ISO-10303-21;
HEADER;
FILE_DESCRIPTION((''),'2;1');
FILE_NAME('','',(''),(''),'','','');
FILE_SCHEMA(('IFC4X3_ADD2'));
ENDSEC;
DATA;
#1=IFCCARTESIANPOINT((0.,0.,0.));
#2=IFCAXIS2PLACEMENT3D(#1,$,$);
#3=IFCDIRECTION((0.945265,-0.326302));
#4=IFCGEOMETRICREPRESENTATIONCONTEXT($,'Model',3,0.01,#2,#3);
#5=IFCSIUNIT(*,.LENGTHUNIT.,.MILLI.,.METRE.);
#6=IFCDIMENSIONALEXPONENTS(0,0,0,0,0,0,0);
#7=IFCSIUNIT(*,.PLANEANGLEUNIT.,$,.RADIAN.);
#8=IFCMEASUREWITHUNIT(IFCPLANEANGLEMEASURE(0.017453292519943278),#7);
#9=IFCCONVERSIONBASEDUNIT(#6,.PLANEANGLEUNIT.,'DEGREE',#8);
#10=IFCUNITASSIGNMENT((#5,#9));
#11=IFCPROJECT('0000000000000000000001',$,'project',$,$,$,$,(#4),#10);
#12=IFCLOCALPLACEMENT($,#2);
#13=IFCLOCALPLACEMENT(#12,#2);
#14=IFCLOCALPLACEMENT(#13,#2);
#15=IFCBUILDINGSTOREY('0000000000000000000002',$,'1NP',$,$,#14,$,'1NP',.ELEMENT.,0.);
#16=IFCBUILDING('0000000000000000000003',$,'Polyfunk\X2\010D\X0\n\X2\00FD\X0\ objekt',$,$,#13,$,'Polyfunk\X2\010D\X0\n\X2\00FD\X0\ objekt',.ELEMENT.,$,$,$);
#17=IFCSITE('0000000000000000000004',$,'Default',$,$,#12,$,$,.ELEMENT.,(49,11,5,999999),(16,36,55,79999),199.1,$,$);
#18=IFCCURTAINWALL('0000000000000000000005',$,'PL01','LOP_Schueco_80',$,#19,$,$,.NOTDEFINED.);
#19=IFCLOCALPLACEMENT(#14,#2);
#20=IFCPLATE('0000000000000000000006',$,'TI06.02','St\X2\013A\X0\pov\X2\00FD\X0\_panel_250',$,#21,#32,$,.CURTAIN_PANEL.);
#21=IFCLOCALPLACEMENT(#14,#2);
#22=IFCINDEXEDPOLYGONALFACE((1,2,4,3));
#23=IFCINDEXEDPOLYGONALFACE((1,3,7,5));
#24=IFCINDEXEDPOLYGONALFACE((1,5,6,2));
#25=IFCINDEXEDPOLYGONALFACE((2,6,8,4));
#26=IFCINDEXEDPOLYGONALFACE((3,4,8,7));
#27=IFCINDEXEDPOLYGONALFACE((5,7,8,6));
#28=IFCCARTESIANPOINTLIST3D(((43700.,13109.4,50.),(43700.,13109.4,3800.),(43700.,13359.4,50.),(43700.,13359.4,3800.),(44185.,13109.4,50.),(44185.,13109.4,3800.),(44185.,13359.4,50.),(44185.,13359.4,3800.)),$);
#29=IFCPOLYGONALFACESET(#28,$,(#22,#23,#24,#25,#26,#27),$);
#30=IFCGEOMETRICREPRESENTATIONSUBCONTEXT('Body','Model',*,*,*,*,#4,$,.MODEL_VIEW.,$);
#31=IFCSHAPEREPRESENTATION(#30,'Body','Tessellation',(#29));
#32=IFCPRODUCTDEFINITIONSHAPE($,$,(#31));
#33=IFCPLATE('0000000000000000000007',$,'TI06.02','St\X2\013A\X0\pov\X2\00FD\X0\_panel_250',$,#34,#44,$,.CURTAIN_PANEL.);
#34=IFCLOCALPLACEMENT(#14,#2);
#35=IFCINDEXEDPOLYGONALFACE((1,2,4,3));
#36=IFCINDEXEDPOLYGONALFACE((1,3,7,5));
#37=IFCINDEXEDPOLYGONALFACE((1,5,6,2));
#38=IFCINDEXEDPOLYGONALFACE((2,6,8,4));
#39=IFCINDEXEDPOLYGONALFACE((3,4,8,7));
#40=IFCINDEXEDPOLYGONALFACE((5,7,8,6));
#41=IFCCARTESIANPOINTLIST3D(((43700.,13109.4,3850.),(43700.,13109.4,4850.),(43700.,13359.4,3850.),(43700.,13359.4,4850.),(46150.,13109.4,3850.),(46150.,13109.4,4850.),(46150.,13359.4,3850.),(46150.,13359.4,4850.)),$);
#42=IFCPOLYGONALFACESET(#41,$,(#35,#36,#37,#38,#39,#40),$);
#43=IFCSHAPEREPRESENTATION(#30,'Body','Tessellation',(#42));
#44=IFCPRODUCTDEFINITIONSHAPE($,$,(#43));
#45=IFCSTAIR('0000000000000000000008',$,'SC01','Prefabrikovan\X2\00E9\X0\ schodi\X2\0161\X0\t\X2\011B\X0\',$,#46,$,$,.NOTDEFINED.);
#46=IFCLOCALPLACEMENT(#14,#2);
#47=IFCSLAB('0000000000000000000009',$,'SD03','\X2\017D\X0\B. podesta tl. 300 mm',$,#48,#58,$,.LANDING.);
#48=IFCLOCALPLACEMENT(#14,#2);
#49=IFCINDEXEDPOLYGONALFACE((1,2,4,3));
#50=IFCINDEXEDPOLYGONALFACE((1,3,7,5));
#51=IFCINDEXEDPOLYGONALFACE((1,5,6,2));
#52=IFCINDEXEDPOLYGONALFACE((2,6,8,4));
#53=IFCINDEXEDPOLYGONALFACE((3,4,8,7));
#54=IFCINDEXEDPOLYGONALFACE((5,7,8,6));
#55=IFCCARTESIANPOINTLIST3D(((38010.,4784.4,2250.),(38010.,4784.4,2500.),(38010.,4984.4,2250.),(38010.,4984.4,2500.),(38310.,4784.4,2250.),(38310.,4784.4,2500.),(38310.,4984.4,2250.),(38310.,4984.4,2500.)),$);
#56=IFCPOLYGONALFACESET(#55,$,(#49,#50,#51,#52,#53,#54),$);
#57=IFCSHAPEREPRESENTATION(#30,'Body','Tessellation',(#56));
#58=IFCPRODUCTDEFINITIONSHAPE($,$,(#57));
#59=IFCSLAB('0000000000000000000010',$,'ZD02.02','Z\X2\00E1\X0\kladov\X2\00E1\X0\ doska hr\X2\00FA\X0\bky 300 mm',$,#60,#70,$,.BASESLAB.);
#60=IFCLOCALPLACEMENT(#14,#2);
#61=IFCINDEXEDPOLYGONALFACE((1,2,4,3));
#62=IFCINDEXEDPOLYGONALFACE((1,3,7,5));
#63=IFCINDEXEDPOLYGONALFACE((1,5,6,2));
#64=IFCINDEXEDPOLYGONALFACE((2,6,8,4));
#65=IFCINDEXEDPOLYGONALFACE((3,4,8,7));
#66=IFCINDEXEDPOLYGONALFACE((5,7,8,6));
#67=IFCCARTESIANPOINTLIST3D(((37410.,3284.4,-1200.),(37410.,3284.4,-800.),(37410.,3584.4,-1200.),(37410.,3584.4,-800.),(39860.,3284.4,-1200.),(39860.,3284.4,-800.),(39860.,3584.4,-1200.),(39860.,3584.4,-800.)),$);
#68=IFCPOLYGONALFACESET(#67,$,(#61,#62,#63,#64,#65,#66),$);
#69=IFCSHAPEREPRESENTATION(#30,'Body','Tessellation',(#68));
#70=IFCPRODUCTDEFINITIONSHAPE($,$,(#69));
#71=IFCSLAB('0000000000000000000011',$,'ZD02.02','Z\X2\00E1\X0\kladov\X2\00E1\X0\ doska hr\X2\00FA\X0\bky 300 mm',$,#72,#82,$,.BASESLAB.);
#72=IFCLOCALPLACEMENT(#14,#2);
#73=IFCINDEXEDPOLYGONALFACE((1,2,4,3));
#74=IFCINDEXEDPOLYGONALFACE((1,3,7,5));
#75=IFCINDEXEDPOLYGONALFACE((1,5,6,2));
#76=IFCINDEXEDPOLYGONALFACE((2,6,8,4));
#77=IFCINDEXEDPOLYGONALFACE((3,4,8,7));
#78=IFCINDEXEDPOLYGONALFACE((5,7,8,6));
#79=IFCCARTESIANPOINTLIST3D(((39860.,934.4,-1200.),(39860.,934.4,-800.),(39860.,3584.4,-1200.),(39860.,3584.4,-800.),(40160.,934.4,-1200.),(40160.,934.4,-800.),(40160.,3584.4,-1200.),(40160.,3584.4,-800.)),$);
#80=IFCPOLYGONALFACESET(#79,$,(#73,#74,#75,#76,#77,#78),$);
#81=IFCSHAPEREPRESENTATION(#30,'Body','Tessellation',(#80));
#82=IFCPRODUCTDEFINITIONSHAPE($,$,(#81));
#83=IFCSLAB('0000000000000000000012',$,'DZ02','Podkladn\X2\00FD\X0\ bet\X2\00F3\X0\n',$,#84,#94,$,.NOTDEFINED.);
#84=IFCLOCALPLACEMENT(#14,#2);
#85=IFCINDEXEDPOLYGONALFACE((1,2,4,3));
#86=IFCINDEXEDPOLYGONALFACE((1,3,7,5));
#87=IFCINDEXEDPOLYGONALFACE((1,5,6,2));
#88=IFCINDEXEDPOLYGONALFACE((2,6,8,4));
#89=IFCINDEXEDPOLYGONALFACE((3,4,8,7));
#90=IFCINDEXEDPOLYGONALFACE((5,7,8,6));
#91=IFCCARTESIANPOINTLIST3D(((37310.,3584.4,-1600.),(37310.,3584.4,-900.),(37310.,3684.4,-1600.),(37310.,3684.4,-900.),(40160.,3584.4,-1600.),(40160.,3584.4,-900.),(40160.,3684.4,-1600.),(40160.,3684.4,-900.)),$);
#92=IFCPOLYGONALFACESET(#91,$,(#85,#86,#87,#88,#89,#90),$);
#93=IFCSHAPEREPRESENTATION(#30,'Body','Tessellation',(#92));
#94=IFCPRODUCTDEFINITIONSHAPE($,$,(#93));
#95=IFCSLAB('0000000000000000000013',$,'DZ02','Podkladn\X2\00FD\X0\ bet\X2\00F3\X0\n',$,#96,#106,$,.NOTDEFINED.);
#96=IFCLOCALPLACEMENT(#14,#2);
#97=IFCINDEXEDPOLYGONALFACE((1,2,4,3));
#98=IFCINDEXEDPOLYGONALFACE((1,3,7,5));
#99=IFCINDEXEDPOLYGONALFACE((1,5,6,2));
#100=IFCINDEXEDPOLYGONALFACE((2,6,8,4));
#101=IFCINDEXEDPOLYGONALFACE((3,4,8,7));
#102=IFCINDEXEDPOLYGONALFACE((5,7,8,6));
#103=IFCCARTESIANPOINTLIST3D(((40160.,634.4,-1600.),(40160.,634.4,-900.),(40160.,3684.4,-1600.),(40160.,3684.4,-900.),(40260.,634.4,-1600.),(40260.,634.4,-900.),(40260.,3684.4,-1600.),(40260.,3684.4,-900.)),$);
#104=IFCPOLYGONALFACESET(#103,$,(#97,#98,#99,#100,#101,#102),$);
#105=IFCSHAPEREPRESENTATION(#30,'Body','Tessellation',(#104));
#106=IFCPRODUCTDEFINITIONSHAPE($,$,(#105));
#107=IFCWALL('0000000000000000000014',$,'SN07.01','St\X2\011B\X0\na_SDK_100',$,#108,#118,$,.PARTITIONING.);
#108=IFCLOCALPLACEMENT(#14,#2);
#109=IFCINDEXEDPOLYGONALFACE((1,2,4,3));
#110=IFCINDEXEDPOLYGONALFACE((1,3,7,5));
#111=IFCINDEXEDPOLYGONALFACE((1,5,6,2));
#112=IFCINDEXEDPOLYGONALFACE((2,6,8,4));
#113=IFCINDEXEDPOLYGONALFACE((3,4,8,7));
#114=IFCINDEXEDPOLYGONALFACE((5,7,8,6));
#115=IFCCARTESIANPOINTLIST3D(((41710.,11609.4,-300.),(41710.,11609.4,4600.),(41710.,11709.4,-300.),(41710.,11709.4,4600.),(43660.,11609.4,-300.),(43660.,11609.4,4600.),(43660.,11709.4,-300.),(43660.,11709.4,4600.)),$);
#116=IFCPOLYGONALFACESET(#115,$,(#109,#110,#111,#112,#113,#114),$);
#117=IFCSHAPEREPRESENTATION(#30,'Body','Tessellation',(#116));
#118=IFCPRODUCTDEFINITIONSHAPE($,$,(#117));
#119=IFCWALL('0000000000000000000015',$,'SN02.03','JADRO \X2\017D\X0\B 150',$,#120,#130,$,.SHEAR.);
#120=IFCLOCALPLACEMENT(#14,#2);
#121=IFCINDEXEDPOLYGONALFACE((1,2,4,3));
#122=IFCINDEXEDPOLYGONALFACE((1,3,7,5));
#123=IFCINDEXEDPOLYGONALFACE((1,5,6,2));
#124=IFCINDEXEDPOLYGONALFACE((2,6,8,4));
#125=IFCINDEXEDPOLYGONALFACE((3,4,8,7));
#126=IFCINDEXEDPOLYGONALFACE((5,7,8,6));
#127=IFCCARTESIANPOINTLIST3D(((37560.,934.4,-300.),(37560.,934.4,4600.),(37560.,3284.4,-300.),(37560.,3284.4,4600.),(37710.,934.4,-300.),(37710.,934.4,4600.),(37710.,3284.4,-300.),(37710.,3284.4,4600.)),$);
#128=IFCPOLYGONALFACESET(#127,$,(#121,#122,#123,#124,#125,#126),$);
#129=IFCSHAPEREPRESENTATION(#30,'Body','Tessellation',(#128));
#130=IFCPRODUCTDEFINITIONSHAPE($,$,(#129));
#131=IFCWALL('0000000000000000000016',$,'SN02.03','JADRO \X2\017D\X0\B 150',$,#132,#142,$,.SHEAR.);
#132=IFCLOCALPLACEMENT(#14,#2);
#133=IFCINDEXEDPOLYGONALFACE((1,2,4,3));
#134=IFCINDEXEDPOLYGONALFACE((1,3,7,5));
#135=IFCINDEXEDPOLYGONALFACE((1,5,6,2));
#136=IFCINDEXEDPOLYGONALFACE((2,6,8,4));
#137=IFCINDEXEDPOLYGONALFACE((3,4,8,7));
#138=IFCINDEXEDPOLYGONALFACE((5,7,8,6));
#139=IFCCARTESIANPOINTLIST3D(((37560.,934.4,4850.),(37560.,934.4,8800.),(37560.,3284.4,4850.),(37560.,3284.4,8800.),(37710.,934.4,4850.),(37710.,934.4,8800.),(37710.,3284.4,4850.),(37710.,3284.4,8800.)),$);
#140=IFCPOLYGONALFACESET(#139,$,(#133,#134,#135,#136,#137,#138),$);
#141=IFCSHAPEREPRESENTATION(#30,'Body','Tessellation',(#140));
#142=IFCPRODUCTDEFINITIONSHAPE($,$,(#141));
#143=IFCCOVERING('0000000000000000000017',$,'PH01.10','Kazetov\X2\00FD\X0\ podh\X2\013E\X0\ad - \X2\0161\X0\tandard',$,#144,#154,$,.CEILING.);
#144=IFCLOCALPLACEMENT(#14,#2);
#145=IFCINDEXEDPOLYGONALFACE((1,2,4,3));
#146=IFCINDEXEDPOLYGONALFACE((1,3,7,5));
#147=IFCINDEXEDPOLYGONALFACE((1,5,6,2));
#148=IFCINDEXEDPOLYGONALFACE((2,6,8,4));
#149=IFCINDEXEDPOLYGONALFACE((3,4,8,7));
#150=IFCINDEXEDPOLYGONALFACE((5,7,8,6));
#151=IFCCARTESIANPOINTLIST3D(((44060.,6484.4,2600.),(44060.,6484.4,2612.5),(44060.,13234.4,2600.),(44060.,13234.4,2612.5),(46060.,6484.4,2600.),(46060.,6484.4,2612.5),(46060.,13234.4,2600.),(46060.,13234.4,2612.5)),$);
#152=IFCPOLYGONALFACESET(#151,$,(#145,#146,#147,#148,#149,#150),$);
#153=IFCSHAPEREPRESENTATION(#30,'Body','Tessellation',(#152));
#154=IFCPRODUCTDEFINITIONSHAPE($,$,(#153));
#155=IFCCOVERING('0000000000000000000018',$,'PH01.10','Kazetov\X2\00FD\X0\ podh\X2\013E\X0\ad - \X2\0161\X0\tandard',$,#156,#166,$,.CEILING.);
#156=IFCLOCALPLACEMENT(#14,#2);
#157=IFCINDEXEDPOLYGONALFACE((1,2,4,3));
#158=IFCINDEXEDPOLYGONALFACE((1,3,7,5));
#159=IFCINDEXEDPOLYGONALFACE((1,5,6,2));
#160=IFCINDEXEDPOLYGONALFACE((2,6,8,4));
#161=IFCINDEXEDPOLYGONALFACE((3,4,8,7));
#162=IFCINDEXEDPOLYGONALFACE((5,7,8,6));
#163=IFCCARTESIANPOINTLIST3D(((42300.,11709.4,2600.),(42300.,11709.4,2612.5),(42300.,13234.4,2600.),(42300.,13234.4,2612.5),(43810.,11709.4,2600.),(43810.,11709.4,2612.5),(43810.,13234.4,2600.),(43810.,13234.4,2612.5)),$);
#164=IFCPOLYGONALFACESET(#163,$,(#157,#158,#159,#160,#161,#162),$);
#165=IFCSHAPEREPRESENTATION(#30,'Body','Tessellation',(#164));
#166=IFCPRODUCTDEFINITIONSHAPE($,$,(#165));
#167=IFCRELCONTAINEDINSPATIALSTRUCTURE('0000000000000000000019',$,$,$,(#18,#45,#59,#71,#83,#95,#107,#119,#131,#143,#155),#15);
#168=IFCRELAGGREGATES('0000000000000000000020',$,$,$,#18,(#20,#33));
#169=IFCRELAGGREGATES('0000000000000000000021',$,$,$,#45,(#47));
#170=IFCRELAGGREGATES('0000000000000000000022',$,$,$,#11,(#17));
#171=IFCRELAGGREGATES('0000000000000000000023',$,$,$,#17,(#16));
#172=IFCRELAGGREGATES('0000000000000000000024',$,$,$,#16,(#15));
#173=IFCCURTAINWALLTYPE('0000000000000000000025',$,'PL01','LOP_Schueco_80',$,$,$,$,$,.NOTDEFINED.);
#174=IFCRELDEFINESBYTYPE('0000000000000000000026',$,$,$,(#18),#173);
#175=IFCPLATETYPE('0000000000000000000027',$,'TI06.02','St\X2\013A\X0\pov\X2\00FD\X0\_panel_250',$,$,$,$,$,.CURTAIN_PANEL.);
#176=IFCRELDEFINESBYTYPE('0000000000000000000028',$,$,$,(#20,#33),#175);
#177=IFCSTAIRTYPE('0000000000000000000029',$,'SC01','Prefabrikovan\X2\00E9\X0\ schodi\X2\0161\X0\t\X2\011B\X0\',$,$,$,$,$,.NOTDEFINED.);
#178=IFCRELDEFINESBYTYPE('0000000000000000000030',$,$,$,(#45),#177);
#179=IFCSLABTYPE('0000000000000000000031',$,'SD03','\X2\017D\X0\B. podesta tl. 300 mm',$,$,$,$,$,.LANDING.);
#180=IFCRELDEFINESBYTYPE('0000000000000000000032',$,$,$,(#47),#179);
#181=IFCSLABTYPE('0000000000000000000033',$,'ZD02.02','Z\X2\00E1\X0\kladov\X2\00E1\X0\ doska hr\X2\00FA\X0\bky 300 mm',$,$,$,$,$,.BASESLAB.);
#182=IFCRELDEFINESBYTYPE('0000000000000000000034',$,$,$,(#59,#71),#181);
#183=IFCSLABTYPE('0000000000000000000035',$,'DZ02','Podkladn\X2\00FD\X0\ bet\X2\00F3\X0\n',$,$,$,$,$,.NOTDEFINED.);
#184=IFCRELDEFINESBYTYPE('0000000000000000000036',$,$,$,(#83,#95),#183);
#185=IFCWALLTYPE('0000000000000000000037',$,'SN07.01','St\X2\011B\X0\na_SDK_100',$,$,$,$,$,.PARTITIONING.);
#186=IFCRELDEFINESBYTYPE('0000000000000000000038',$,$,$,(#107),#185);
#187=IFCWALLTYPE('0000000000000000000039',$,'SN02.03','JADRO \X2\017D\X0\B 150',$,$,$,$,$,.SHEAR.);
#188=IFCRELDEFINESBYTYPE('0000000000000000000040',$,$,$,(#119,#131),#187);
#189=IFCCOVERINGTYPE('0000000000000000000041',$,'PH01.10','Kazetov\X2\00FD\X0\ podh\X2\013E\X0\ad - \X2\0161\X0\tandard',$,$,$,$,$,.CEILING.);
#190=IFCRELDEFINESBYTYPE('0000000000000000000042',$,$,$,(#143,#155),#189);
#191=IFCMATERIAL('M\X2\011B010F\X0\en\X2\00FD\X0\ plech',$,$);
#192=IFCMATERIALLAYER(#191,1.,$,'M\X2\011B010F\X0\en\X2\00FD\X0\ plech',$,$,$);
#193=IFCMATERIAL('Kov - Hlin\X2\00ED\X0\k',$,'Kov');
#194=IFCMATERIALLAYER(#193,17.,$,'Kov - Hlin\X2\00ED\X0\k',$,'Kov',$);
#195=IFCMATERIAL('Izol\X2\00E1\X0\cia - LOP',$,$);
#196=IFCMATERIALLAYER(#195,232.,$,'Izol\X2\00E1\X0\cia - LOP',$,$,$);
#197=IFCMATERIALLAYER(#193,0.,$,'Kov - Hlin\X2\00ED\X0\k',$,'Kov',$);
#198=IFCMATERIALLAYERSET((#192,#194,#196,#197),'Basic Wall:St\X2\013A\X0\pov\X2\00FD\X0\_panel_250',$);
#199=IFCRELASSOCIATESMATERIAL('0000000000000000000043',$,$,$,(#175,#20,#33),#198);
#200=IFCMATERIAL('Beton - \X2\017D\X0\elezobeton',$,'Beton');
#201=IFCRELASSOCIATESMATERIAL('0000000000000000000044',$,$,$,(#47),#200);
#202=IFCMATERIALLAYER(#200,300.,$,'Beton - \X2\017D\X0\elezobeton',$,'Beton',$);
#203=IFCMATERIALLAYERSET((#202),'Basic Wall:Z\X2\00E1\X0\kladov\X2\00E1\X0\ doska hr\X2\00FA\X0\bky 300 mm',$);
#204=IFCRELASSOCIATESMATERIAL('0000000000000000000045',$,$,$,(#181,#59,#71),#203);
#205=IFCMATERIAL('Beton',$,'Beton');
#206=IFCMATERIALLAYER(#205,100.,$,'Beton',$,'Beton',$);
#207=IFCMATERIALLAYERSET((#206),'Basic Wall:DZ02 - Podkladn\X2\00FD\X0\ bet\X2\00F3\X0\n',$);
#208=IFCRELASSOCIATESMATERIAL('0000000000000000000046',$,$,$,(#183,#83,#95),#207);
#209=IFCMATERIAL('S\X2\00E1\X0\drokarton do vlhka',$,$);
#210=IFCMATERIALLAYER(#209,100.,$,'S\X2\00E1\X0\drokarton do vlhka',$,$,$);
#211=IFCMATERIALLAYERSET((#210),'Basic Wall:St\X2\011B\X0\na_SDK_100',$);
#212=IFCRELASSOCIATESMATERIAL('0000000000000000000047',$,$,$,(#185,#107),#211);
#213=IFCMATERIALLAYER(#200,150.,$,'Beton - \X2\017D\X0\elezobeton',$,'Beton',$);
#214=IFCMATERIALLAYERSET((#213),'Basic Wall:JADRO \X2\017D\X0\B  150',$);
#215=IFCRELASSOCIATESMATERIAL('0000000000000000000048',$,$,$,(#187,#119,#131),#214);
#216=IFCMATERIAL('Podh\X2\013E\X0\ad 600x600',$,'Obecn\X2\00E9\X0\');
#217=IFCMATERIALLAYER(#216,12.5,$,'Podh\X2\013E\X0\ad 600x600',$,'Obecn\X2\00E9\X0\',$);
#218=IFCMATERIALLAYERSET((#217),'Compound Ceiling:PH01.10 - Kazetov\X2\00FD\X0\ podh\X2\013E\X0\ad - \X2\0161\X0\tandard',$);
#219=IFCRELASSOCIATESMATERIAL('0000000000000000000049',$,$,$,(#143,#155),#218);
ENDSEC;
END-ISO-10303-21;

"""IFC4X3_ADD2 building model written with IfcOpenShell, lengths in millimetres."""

from ifc_helpers import new_model, entity, si_unit, converted_unit, direction, frame, frame_2d, origin, place, context, subcontext, project, spatial, polyline, rectangle, extrude, clip, bounded_halfspace, material, layer, layer_set, layer_usage, type_object, element, aggregate, save


model = new_model("IFC4X3_ADD2")

# Units and contexts
model_context = context("Model", 3, precision=0.01, world=origin(), true_north=direction((0.945265, -0.326302)))
body_context = subcontext(model_context, "Body", "Model", "MODEL_VIEW")
ifc_project = project(units=[si_unit("LENGTHUNIT", "METRE", prefix="MILLI"), converted_unit("PLANEANGLEUNIT", "DEGREE", entity("IfcPlaneAngleMeasure", 0.017453292519943278), si_unit("PLANEANGLEUNIT", "RADIAN"), dimensions=[0, 0, 0, 0, 0, 0, 0])], contexts=[model_context])

# Site, building, storey
site_placement = place(None, origin())
site = spatial("IfcSite", under=ifc_project, at=site_placement, Name="Default", CompositionType="ELEMENT", RefLatitude=(49, 11, 5, 999999), RefLongitude=(16, 36, 55, 79999), RefElevation=199.1)
building_placement = place(site_placement, origin())
building = spatial("IfcBuilding", under=site, at=building_placement, Name="Polyfunkčný objekt", LongName="Polyfunkčný objekt", CompositionType="ELEMENT")
storey_placement = place(building_placement, origin())
storey = spatial("IfcBuildingStorey", under=building, at=storey_placement, Name="1NP", LongName="1NP", CompositionType="ELEMENT", Elevation=0.0)

# Curtain wall, plates
curtain_wall_type = type_object("IfcCurtainWallType", Name="PL01", Description="LOP_Schueco_80", PredefinedType="NOTDEFINED")
curtain_wall_placement = place(storey_placement, origin())
curtain_wall = element("IfcCurtainWall", 1, at=curtain_wall_placement, inside=storey, type_object=curtain_wall_type, Name="PL01", Description="LOP_Schueco_80", PredefinedType="NOTDEFINED")
ifc_material_1 = material(Name="Měďený plech")
ifc_layer_1 = layer(ifc_material_1, 1.0, Name="Měďený plech")
ifc_material_2 = material(Name="Kov - Hliník", Category="Kov")
ifc_layer_2 = layer(ifc_material_2, 17.0, Name="Kov - Hliník", Category="Kov")
ifc_material_3 = material(Name="Izolácia - LOP")
ifc_layer_3 = layer(ifc_material_3, 232.0, Name="Izolácia - LOP")
ifc_layer_4 = layer(ifc_material_2, 0.0, Name="Kov - Hliník", Category="Kov")
ifc_layer_set_1 = layer_set([ifc_layer_1, ifc_layer_2, ifc_layer_3, ifc_layer_4], Name="Basic Wall:Stĺpový_panel_250")
ifc_layer_usage_1 = layer_usage(ifc_layer_set_1, "AXIS2", "NEGATIVE", 125.0)
plate_type = type_object("IfcPlateType", Name="TI06.02", Description="Stĺpový_panel_250", PredefinedType="CURTAIN_PANEL", material=ifc_layer_set_1)
plate_1_placement = place(storey_placement, frame((43700.0, 13234.4, 50.0)))
plate_1 = element("IfcPlate", 2, at=plate_1_placement, type_object=plate_type, material=ifc_layer_usage_1, Name="TI06.02", Description="Stĺpový_panel_250", PredefinedType="CURTAIN_PANEL", context=body_context, shape_type="SweptSolid", body=[
    extrude(rectangle(XDim=250.0, YDim=485.0, at=frame_2d((0.0, 0.0), x_axis=(1.0, 0.0))), frame((242.5, 0.0, 0.0), z_axis=(0.0, 0.0, 1.0), x_axis=(0.0, 1.0, 0.0)), (0.0, 0.0, 1.0), 3750.0),
])
ifc_layer_usage_2 = layer_usage(ifc_layer_set_1, "AXIS2", "NEGATIVE", 125.0)
plate_2_placement = place(storey_placement, frame((43700.0, 13234.4, 3850.0)))
plate_2 = element("IfcPlate", 3, at=plate_2_placement, type_object=plate_type, material=ifc_layer_usage_2, Name="TI06.02", Description="Stĺpový_panel_250", PredefinedType="CURTAIN_PANEL", context=body_context, shape_type="SweptSolid", body=[
    extrude(rectangle(XDim=250.0, YDim=2450.0, at=frame_2d((0.0, 0.0), x_axis=(1.0, 0.0))), frame((1225.0, 0.0, 0.0), z_axis=(0.0, 0.0, 1.0), x_axis=(0.0, 1.0, 0.0)), (0.0, 0.0, 1.0), 1000.0),
])
aggregate(curtain_wall, [plate_1, plate_2])

# Stair, slab
stair_type = type_object("IfcStairType", Name="SC01", Description="Prefabrikované schodiště", PredefinedType="NOTDEFINED")
stair_placement = place(storey_placement, origin())
stair = element("IfcStair", 4, at=stair_placement, inside=storey, type_object=stair_type, Name="SC01", Description="Prefabrikované schodiště", PredefinedType="NOTDEFINED")
ifc_material_4 = material(Name="Beton - Železobeton", Category="Beton")
slab_type_1 = type_object("IfcSlabType", Name="SD03", Description="ŽB. podesta tl. 300 mm", PredefinedType="LANDING")
slab_1_placement = place(stair_placement, frame((38010.0, 4784.4, 0.0)))
slab_1 = element("IfcSlab", 5, at=slab_1_placement, type_object=slab_type_1, material=ifc_material_4, Name="SD03", Description="ŽB. podesta tl. 300 mm", PredefinedType="LANDING", context=body_context, shape_type="SweptSolid", body=[
    extrude(rectangle(XDim=200.0, YDim=300.0, at=frame_2d((0.0, 0.0), x_axis=(1.0, 0.0))), frame((150.0, 100.0, 2250.0), z_axis=(0.0, 0.0, 1.0), x_axis=(0.0, 1.0, 0.0)), (0.0, 0.0, 1.0), 250.0),
])
aggregate(stair, [slab_1])

# Slabs
ifc_layer_5 = layer(ifc_material_4, 300.0, Name="Beton - Železobeton", Category="Beton")
ifc_layer_set_2 = layer_set([ifc_layer_5], Name="Basic Wall:Základová doska hrúbky 300 mm")
slab_type_2 = type_object("IfcSlabType", Name="ZD02.02", Description="Základová doska hrúbky 300 mm", PredefinedType="BASESLAB", material=ifc_layer_set_2)
slab_2_placement = place(storey_placement, frame((37410.0, 3434.4, -1200.0)))
element("IfcSlab", 6, at=slab_2_placement, inside=storey, type_object=slab_type_2, material=ifc_layer_set_2, Name="ZD02.02", Description="Základová doska hrúbky 300 mm", PredefinedType="BASESLAB", context=body_context, shape_type="SweptSolid", body=[
    extrude(rectangle(XDim=2450.0, YDim=300.0, at=frame_2d((1225.0, 0.0), x_axis=(-1.0, 0.0))), origin(), (0.0, 0.0, 1.0), 400.0),
])
slab_3_placement = place(storey_placement, frame((40010.0, 3584.4, -1200.0), z_axis=(0.0, 0.0, 1.0), x_axis=(0.0, -1.0, 0.0)))
element("IfcSlab", 7, at=slab_3_placement, inside=storey, type_object=slab_type_2, material=ifc_layer_set_2, Name="ZD02.02", Description="Základová doska hrúbky 300 mm", PredefinedType="BASESLAB", context=body_context, shape_type="SweptSolid", body=[
    extrude(rectangle(XDim=2650.0, YDim=300.0, at=frame_2d((1325.0, 0.0), x_axis=(-1.0, 0.0))), origin(), (0.0, 0.0, 1.0), 400.0),
])
ifc_material_5 = material(Name="Beton", Category="Beton")
ifc_layer_6 = layer(ifc_material_5, 100.0, Name="Beton", Category="Beton")
ifc_layer_set_3 = layer_set([ifc_layer_6], Name="Basic Wall:DZ02 - Podkladný betón")
slab_type_3 = type_object("IfcSlabType", Name="DZ02", Description="Podkladný betón", PredefinedType="NOTDEFINED", material=ifc_layer_set_3)
slab_4_placement = place(storey_placement, frame((37310.0, 3634.4, -1600.0)))
element("IfcSlab", 8, at=slab_4_placement, inside=storey, type_object=slab_type_3, material=ifc_layer_set_3, Name="DZ02", Description="Podkladný betón", PredefinedType="NOTDEFINED", context=body_context, shape_type="SweptSolid", body=[
    extrude(rectangle(XDim=2850.0, YDim=100.0, at=frame_2d((1425.0, 0.0), x_axis=(-1.0, 0.0))), origin(), (0.0, 0.0, 1.0), 700.0),
])
slab_5_placement = place(storey_placement, frame((40210.0, 3684.4, -1600.0), z_axis=(0.0, 0.0, 1.0), x_axis=(0.0, -1.0, 0.0)))
element("IfcSlab", 9, at=slab_5_placement, inside=storey, type_object=slab_type_3, material=ifc_layer_set_3, Name="DZ02", Description="Podkladný betón", PredefinedType="NOTDEFINED", context=body_context, shape_type="SweptSolid", body=[
    extrude(rectangle(XDim=3050.0, YDim=100.0, at=frame_2d((1525.0, 0.0), x_axis=(-1.0, 0.0))), origin(), (0.0, 0.0, 1.0), 700.0),
])

# Walls
ifc_material_6 = material(Name="Sádrokarton do vlhka")
ifc_layer_7 = layer(ifc_material_6, 100.0, Name="Sádrokarton do vlhka")
ifc_layer_set_4 = layer_set([ifc_layer_7], Name="Basic Wall:Stěna_SDK_100")
wall_type_1 = type_object("IfcWallType", Name="SN07.01", Description="Stěna_SDK_100", PredefinedType="PARTITIONING", material=ifc_layer_set_4)
wall_1_placement = place(storey_placement, frame((41710.0, 11659.4, -300.0)))
element("IfcWall", 10, at=wall_1_placement, inside=storey, type_object=wall_type_1, material=ifc_layer_set_4, Name="SN07.01", Description="Stěna_SDK_100", PredefinedType="PARTITIONING", context=body_context, shape_type="Clipping", body=[
    clip(clip(extrude(rectangle(XDim=1950.0, YDim=100.0, at=frame_2d((975.0, 0.0), x_axis=(-1.0, 0.0))), origin(), (0.0, 0.0, 1.0), 4900.0), bounded_halfspace(frame((0.0, -50.0, 4900.0), z_axis=(0.0, 0.0, -1.0), x_axis=(1.0, 0.0, 0.0)), True, frame((0.0, -50.0, 4900.0)), polyline([(0.0, 0.0), (900.0, 0.0), (1050.0, 0.0), (1950.0, 0.0), (1950.0, 100.0), (0.0, 100.0), (0.0, 0.0)]))), bounded_halfspace(frame((1950.0, -50.0, 0.0), z_axis=(0.0, 0.0, 1.0), x_axis=(0.0, 1.0, 0.0)), True, frame((1950.0, -50.0, 0.0)), polyline([(0.0, 0.0), (0.0, 100.0), (-1950.0, 100.0), (-1950.0, 0.0), (-1050.0, 0.0), (-900.0, 0.0), (0.0, 0.0)]))),
])
ifc_layer_8 = layer(ifc_material_4, 150.0, Name="Beton - Železobeton", Category="Beton")
ifc_layer_set_5 = layer_set([ifc_layer_8], Name="Basic Wall:JADRO ŽB  150")
wall_type_2 = type_object("IfcWallType", Name="SN02.03", Description="JADRO ŽB 150", PredefinedType="SHEAR", material=ifc_layer_set_5)
wall_2_placement = place(storey_placement, frame((37635.0, 3284.4, -300.0), z_axis=(0.0, 0.0, 1.0), x_axis=(0.0, -1.0, 0.0)))
element("IfcWall", 11, at=wall_2_placement, inside=storey, type_object=wall_type_2, material=ifc_layer_set_5, Name="SN02.03", Description="JADRO ŽB 150", PredefinedType="SHEAR", context=body_context, shape_type="SweptSolid", body=[
    extrude(rectangle(XDim=2350.0, YDim=150.0, at=frame_2d((1175.0, 0.0), x_axis=(-1.0, 0.0))), origin(), (0.0, 0.0, 1.0), 4900.0),
])
wall_3_placement = place(storey_placement, frame((37635.0, 3284.4, 4850.0), z_axis=(0.0, 0.0, 1.0), x_axis=(0.0, -1.0, 0.0)))
element("IfcWall", 12, at=wall_3_placement, inside=storey, type_object=wall_type_2, material=ifc_layer_set_5, Name="SN02.03", Description="JADRO ŽB 150", PredefinedType="SHEAR", context=body_context, shape_type="SweptSolid", body=[
    extrude(rectangle(XDim=2350.0, YDim=150.0, at=frame_2d((1175.0, 0.0), x_axis=(-1.0, 0.0))), origin(), (0.0, 0.0, 1.0), 3950.0),
])

# Coverings
ifc_material_7 = material(Name="Podhľad 600x600", Category="Obecné")
ifc_layer_9 = layer(ifc_material_7, 12.5, Name="Podhľad 600x600", Category="Obecné")
ifc_layer_set_6 = layer_set([ifc_layer_9], Name="Compound Ceiling:PH01.10 - Kazetový podhľad - štandard")
ifc_layer_usage_3 = layer_usage(ifc_layer_set_6, "AXIS3", "NEGATIVE", 0.0)
covering_type_1 = type_object("IfcCoveringType", Name="PH01.10", Description="Kazetový podhľad - štandard", PredefinedType="CEILING")
covering_1_placement = place(storey_placement, frame((44060.0, 6484.4, 2600.0)))
element("IfcCovering", 13, at=covering_1_placement, inside=storey, type_object=covering_type_1, material=ifc_layer_usage_3, Name="PH01.10", Description="Kazetový podhľad - štandard", PredefinedType="CEILING", context=body_context, shape_type="SweptSolid", body=[
    extrude(rectangle(XDim=2000.0, YDim=6750.0, at=frame_2d((0.0, 0.0), x_axis=(1.0, 0.0))), frame((1000.0, 3375.0, 0.0), z_axis=(0.0, 0.0, 1.0), x_axis=(-1.0, 0.0, 0.0)), (0.0, 0.0, 1.0), 12.5),
])
ifc_layer_usage_4 = layer_usage(ifc_layer_set_6, "AXIS3", "NEGATIVE", 0.0)
covering_2_placement = place(storey_placement, frame((42300.0, 11709.4, 2600.0)))
element("IfcCovering", 14, at=covering_2_placement, inside=storey, type_object=covering_type_1, material=ifc_layer_usage_4, Name="PH01.10", Description="Kazetový podhľad - štandard", PredefinedType="CEILING", context=body_context, shape_type="SweptSolid", body=[
    extrude(rectangle(XDim=1510.0, YDim=1525.0, at=frame_2d((0.0, 0.0), x_axis=(1.0, 0.0))), frame((755.0, 762.5, 0.0), z_axis=(0.0, 0.0, 1.0), x_axis=(-1.0, 0.0, 0.0)), (0.0, 0.0, 1.0), 12.5),
])

save(model, "model.ifc")
